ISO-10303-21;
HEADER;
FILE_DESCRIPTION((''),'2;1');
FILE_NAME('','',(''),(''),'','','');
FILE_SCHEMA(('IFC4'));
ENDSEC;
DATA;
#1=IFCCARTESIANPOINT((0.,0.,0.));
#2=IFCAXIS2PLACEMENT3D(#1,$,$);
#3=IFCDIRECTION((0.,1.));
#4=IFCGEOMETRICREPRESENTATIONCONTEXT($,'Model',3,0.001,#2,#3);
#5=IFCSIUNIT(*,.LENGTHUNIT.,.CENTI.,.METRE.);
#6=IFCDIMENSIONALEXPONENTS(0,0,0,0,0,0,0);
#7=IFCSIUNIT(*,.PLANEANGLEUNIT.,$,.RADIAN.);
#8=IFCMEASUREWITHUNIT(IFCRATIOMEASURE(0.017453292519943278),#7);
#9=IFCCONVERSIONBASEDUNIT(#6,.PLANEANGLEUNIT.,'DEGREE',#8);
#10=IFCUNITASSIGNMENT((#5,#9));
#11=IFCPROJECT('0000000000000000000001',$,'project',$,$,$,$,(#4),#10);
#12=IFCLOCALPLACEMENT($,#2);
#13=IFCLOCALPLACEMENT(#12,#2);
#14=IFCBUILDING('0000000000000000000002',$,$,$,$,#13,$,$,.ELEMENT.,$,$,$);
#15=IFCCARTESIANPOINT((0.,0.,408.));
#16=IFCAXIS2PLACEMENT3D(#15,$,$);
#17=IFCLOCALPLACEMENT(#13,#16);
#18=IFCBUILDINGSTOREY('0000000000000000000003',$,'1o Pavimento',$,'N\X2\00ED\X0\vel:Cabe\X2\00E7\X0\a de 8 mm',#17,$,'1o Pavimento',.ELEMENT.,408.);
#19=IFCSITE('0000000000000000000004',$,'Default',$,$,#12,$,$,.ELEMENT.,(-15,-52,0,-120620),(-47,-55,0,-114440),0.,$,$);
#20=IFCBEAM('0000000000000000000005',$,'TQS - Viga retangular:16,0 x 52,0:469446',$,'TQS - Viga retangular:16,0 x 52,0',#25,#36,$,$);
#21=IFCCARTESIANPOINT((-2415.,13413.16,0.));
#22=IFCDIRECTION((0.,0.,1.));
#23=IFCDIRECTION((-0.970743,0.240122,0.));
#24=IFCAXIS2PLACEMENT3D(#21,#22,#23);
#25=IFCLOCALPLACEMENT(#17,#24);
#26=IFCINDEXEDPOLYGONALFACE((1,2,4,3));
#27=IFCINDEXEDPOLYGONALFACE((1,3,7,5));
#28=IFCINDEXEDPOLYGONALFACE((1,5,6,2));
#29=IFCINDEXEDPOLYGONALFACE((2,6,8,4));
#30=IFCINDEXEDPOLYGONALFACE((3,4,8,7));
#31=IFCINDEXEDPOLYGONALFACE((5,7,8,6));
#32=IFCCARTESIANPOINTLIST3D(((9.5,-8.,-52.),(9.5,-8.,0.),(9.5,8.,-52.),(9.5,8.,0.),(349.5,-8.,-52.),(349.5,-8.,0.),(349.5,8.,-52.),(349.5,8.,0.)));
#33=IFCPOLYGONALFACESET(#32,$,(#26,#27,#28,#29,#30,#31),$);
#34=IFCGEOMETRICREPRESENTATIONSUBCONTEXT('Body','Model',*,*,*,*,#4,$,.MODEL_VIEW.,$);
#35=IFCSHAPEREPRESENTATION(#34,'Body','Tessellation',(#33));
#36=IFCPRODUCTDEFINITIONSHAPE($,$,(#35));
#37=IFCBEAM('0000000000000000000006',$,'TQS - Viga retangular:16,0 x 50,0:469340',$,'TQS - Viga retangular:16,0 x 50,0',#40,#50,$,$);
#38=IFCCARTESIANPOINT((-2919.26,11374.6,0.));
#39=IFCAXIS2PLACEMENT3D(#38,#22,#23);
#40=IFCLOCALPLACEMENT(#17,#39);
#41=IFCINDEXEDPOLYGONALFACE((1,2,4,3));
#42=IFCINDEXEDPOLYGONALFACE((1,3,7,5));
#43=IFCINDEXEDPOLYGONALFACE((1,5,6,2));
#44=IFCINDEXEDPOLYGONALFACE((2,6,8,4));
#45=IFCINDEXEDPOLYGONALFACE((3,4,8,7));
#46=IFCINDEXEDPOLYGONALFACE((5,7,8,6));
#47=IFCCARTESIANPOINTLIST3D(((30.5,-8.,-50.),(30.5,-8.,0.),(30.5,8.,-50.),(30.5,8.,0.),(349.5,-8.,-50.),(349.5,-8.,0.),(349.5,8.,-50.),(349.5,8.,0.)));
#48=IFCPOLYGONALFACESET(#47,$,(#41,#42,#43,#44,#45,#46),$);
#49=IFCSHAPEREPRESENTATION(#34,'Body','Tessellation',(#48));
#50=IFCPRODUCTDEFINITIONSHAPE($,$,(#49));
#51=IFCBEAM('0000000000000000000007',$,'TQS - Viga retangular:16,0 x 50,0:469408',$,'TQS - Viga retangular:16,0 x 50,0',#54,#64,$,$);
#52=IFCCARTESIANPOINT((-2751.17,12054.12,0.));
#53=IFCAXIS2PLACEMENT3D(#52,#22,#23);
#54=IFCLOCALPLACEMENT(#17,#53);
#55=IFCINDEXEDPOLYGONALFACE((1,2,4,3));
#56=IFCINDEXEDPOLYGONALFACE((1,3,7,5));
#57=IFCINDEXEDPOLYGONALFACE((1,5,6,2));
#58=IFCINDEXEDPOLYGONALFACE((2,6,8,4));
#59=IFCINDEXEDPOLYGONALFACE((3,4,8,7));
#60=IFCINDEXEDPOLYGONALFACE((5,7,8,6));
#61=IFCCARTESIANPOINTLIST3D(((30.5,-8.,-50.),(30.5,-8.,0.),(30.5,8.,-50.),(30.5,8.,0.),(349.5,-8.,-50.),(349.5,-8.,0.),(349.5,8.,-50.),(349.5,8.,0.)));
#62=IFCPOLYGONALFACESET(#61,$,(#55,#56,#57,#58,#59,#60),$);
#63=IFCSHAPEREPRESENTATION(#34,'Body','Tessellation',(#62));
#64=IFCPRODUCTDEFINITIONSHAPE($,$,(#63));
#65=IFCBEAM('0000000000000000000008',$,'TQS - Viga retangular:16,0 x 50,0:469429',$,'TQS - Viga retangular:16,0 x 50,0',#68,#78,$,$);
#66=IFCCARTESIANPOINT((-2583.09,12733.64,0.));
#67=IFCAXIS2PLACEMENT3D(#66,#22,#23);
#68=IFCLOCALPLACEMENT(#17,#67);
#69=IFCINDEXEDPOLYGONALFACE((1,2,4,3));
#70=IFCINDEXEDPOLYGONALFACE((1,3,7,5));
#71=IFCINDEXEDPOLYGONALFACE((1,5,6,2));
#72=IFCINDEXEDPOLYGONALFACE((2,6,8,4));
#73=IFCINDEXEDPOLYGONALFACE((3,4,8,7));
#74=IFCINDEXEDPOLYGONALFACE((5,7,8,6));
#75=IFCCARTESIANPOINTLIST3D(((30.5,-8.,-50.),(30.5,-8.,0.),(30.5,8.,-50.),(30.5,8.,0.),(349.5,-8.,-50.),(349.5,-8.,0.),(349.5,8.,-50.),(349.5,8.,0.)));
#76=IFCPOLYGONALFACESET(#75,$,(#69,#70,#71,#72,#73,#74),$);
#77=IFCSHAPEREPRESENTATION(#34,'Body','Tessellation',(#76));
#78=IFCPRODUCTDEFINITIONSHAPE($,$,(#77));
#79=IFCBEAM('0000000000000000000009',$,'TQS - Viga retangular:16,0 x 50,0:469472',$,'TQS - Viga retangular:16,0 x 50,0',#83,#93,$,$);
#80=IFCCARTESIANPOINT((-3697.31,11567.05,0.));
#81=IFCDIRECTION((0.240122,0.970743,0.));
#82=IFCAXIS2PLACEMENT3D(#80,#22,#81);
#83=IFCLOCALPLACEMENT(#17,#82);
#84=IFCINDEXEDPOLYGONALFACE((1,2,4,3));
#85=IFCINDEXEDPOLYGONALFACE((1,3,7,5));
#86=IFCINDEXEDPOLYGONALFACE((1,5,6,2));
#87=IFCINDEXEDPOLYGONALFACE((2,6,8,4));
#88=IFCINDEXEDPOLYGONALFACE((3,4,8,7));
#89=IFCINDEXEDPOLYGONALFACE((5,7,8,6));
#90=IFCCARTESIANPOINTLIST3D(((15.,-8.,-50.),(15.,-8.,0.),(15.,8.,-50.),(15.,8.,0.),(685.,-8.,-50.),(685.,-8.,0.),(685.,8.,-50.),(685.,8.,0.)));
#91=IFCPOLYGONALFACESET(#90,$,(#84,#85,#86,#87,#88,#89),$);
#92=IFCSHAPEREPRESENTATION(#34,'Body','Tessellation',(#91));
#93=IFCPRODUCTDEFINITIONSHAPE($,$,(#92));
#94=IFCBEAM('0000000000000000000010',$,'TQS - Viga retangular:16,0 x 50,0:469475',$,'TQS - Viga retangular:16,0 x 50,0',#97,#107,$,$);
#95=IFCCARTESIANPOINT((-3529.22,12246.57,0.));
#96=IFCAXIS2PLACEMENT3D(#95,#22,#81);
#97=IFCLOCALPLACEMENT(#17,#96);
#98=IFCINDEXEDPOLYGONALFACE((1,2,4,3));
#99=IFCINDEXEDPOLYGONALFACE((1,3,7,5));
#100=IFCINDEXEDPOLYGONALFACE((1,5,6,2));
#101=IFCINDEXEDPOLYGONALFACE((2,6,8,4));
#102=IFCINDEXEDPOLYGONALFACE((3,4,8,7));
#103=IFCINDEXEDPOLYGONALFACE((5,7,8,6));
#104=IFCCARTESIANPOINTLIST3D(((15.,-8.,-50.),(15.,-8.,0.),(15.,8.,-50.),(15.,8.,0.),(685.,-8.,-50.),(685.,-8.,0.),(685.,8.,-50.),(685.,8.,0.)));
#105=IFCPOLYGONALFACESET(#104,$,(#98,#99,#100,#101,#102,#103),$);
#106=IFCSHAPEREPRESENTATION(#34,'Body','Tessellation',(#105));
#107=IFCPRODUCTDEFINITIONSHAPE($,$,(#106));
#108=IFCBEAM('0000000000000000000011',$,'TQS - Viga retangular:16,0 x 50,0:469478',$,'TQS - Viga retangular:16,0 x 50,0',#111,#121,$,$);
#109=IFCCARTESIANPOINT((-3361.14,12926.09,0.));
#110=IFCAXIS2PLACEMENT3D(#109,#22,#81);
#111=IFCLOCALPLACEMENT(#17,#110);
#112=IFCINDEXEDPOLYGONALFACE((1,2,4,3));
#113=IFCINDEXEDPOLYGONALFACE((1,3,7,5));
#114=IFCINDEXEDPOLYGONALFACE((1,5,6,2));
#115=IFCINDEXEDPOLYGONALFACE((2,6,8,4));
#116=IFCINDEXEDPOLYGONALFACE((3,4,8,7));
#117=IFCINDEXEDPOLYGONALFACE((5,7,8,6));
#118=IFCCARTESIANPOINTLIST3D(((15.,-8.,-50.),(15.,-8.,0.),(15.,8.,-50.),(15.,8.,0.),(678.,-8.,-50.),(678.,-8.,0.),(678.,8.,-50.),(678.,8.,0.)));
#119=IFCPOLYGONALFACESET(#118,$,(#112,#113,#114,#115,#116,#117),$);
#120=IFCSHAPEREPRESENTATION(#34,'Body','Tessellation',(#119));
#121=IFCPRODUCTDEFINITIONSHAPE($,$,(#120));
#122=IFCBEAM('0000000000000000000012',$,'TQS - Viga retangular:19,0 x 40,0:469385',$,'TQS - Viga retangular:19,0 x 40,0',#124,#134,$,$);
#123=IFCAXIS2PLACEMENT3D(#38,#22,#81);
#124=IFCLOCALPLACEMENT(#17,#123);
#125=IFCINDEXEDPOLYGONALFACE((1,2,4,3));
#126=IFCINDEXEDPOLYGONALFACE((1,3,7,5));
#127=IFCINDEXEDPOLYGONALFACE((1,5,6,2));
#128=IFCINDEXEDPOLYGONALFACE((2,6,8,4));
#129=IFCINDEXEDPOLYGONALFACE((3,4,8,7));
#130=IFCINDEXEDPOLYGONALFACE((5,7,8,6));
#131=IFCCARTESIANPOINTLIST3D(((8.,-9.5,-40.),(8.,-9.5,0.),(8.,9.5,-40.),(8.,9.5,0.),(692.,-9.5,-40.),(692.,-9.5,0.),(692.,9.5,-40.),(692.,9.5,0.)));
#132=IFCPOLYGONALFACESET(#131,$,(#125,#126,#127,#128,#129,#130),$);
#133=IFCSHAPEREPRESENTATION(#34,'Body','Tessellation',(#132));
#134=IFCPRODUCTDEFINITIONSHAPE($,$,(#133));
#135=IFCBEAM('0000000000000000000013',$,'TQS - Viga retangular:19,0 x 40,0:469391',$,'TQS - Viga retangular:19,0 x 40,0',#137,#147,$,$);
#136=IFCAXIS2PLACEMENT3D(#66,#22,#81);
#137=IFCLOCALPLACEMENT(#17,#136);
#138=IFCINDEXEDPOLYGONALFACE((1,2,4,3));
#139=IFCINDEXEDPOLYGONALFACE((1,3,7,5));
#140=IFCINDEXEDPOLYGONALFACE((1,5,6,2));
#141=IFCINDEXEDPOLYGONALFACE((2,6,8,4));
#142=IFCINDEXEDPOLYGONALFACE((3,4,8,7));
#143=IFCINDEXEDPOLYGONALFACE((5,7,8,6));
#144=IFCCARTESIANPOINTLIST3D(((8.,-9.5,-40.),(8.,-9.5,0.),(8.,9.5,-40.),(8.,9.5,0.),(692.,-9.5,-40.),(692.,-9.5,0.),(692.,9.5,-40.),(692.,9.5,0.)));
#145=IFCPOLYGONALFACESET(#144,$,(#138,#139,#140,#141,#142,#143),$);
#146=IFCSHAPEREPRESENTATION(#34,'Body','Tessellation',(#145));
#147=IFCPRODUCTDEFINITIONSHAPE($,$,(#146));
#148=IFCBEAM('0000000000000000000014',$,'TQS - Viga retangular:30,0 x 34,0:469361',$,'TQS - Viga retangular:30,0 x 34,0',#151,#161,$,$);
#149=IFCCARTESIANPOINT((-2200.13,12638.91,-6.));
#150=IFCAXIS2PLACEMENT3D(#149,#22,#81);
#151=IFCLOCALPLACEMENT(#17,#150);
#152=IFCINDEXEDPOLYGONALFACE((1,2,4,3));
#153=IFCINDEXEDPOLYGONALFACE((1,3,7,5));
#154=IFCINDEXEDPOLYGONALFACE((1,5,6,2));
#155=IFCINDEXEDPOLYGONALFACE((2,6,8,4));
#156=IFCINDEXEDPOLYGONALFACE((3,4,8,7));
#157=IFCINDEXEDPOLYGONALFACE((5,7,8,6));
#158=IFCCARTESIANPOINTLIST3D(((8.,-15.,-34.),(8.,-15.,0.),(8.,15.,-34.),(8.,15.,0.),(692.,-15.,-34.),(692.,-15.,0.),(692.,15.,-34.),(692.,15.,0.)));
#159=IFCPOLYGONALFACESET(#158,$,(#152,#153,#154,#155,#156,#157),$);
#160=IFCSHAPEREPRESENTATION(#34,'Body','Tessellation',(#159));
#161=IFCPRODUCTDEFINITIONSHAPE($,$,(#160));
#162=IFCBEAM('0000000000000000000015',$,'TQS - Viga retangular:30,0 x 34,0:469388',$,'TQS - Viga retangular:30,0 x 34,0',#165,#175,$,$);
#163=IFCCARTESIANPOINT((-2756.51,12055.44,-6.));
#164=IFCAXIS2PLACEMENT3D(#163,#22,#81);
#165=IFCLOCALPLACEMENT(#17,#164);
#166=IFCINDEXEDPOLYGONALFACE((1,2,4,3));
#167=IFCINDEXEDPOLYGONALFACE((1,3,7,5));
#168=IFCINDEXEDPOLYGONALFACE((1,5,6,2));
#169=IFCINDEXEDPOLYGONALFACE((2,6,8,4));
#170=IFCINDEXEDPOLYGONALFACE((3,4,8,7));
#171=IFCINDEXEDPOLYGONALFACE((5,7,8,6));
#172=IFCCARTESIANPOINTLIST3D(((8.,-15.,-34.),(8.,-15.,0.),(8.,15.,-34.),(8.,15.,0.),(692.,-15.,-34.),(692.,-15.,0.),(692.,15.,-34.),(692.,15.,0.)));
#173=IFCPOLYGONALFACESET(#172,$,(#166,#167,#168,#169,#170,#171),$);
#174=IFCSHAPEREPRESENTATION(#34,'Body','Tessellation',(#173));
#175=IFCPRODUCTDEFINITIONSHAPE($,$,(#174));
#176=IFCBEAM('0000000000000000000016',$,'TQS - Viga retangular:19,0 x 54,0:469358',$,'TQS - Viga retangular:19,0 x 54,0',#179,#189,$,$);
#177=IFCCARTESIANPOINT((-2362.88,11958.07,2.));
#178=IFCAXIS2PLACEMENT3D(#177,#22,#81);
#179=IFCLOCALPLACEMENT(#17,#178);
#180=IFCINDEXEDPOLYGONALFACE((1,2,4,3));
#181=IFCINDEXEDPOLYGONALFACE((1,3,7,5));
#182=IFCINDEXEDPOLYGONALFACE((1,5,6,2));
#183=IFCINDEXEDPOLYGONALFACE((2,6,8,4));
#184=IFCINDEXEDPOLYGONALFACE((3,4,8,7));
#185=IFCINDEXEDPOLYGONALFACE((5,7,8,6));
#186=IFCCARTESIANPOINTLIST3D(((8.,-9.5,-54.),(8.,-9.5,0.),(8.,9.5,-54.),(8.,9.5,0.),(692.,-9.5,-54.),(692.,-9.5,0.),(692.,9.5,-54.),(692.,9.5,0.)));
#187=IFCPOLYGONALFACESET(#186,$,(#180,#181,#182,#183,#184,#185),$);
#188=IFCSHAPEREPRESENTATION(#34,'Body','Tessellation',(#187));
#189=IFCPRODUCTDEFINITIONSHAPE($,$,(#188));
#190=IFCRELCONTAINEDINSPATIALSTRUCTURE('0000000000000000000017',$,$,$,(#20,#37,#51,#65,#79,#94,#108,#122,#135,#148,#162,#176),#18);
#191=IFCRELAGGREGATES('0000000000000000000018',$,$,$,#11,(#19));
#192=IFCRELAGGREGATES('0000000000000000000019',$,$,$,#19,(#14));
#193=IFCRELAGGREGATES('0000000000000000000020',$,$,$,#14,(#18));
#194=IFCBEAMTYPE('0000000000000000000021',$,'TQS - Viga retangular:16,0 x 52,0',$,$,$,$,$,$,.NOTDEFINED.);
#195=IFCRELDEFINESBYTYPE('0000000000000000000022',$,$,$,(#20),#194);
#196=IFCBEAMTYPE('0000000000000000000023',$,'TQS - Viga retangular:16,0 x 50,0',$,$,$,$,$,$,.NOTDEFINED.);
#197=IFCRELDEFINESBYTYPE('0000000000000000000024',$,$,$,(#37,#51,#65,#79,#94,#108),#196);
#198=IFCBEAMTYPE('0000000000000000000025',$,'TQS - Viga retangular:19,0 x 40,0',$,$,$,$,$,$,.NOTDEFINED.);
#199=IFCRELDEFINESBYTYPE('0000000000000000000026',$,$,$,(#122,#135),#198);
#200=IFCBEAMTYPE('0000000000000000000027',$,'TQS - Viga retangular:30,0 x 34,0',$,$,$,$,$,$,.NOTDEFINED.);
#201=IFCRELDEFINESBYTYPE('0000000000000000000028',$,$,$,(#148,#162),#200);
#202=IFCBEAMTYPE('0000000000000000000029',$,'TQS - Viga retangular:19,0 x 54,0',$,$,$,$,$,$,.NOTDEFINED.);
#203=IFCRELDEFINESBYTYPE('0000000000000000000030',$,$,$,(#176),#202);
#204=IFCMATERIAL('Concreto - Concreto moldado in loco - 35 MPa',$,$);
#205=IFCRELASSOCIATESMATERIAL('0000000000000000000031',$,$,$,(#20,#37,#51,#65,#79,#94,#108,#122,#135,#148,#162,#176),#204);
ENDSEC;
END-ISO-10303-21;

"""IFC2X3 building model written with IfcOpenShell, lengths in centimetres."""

from ifc_helpers import new_model, entity, si_unit, converted_unit, direction, frame, frame_2d, origin, origin_2d_with_axis, place, context, subcontext, project, spatial, rectangle, extrude, material, type_object, element, save


model = new_model("IFC2X3")

# Units and contexts
model_context = context("Model", 3, precision=0.001, world=origin(), true_north=direction((0.0, 1.0)))
body_context = subcontext(model_context, "Body", "Model", "MODEL_VIEW")
ifc_project = project(units=[si_unit("LENGTHUNIT", "METRE", prefix="CENTI"), converted_unit("PLANEANGLEUNIT", "DEGREE", entity("IfcRatioMeasure", 0.017453292519943278), si_unit("PLANEANGLEUNIT", "RADIAN"), dimensions=[0, 0, 0, 0, 0, 0, 0])], contexts=[model_context])

# Site, building, storey
site_placement = place(None, origin())
site = spatial("IfcSite", under=ifc_project, at=site_placement, Name="Default", CompositionType="ELEMENT", RefLatitude=(-15, -52, 0, -120620), RefLongitude=(-47, -55, 0, -114440), RefElevation=0.0)
building_placement = place(site_placement, origin())
building = spatial("IfcBuilding", under=site, at=building_placement, CompositionType="ELEMENT")
storey_placement = place(building_placement, frame((0.0, 0.0, 408.0)))
storey = spatial("IfcBuildingStorey", under=building, at=storey_placement, Name="1o Pavimento", ObjectType="Nível:Cabeça de 8 mm", LongName="1o Pavimento", CompositionType="ELEMENT", Elevation=408.0)

# Beams
ifc_material_1 = material(Name="Concreto - Concreto moldado in loco - 35 MPa")
beam_type_1 = type_object("IfcBeamType", Name="TQS - Viga retangular:16,0 x 52,0", PredefinedType="NOTDEFINED")
beam_1_placement = place(storey_placement, frame((-2415.0, 13413.16, 0.0), z_axis=(0.0, 0.0, 1.0), x_axis=(-0.970743, 0.240122, 0.0)))
element("IfcBeam", 1, at=beam_1_placement, inside=storey, type_object=beam_type_1, material=ifc_material_1, Name="TQS - Viga retangular:16,0 x 52,0:469446", ObjectType="TQS - Viga retangular:16,0 x 52,0", context=body_context, shape_type="SweptSolid", body=[
    extrude(rectangle(XDim=52.0, YDim=16.0, at=frame_2d((0.0, 0.0), x_axis=(1.0, 0.0))), frame((9.5, 0.0, -26.0), z_axis=(1.0, 0.0, 0.0), x_axis=(0.0, 0.0, -1.0)), (0.0, 0.0, 1.0), 340.0),
])
beam_type_2 = type_object("IfcBeamType", Name="TQS - Viga retangular:16,0 x 50,0", PredefinedType="NOTDEFINED")
beam_2_placement = place(storey_placement, frame((-2919.26, 11374.6, 0.0), z_axis=(0.0, 0.0, 1.0), x_axis=(-0.970743, 0.240122, 0.0)))
element("IfcBeam", 2, at=beam_2_placement, inside=storey, type_object=beam_type_2, material=ifc_material_1, Name="TQS - Viga retangular:16,0 x 50,0:469340", ObjectType="TQS - Viga retangular:16,0 x 50,0", context=body_context, shape_type="SweptSolid", body=[
    extrude(rectangle(XDim=50.0, YDim=16.0, at=frame_2d((0.0, 0.0), x_axis=(1.0, 0.0))), frame((30.5, 0.0, -25.0), z_axis=(1.0, 0.0, 0.0), x_axis=(0.0, 0.0, -1.0)), (0.0, 0.0, 1.0), 319.0),
])
beam_3_placement = place(storey_placement, frame((-2751.17, 12054.12, 0.0), z_axis=(0.0, 0.0, 1.0), x_axis=(-0.970743, 0.240122, 0.0)))
element("IfcBeam", 3, at=beam_3_placement, inside=storey, type_object=beam_type_2, material=ifc_material_1, Name="TQS - Viga retangular:16,0 x 50,0:469408", ObjectType="TQS - Viga retangular:16,0 x 50,0", context=body_context, shape_type="SweptSolid", body=[
    extrude(rectangle(XDim=50.0, YDim=16.0, at=frame_2d((0.0, 0.0), x_axis=(1.0, 0.0))), frame((30.5, 0.0, -25.0), z_axis=(1.0, 0.0, 0.0), x_axis=(0.0, 0.0, -1.0)), (0.0, 0.0, 1.0), 319.0),
])
beam_4_placement = place(storey_placement, frame((-2583.09, 12733.64, 0.0), z_axis=(0.0, 0.0, 1.0), x_axis=(-0.970743, 0.240122, 0.0)))
element("IfcBeam", 4, at=beam_4_placement, inside=storey, type_object=beam_type_2, material=ifc_material_1, Name="TQS - Viga retangular:16,0 x 50,0:469429", ObjectType="TQS - Viga retangular:16,0 x 50,0", context=body_context, shape_type="SweptSolid", body=[
    extrude(rectangle(XDim=50.0, YDim=16.0, at=frame_2d((0.0, 0.0), x_axis=(1.0, 0.0))), frame((30.5, 0.0, -25.0), z_axis=(1.0, 0.0, 0.0), x_axis=(0.0, 0.0, -1.0)), (0.0, 0.0, 1.0), 319.0),
])
beam_5_placement = place(storey_placement, frame((-3697.31, 11567.05, 0.0), z_axis=(0.0, 0.0, 1.0), x_axis=(0.240122, 0.970743, 0.0)))
element("IfcBeam", 5, at=beam_5_placement, inside=storey, type_object=beam_type_2, material=ifc_material_1, Name="TQS - Viga retangular:16,0 x 50,0:469472", ObjectType="TQS - Viga retangular:16,0 x 50,0", context=body_context, shape_type="SweptSolid", body=[
    extrude(rectangle(XDim=50.0, YDim=16.0, at=frame_2d((0.0, 0.0), x_axis=(1.0, 0.0))), frame((15.0, 0.0, -25.0), z_axis=(1.0, 0.0, 0.0), x_axis=(0.0, 0.0, -1.0)), (0.0, 0.0, 1.0), 670.0),
])
beam_6_placement = place(storey_placement, frame((-3529.22, 12246.57, 0.0), z_axis=(0.0, 0.0, 1.0), x_axis=(0.240122, 0.970743, 0.0)))
element("IfcBeam", 6, at=beam_6_placement, inside=storey, type_object=beam_type_2, material=ifc_material_1, Name="TQS - Viga retangular:16,0 x 50,0:469475", ObjectType="TQS - Viga retangular:16,0 x 50,0", context=body_context, shape_type="SweptSolid", body=[
    extrude(rectangle(XDim=50.0, YDim=16.0, at=frame_2d((0.0, 0.0), x_axis=(1.0, 0.0))), frame((15.0, 0.0, -25.0), z_axis=(1.0, 0.0, 0.0), x_axis=(0.0, 0.0, -1.0)), (0.0, 0.0, 1.0), 670.0),
])
beam_7_placement = place(storey_placement, frame((-3361.14, 12926.09, 0.0), z_axis=(0.0, 0.0, 1.0), x_axis=(0.240122, 0.970743, 0.0)))
element("IfcBeam", 7, at=beam_7_placement, inside=storey, type_object=beam_type_2, material=ifc_material_1, Name="TQS - Viga retangular:16,0 x 50,0:469478", ObjectType="TQS - Viga retangular:16,0 x 50,0", context=body_context, shape_type="SweptSolid", body=[
    extrude(rectangle(XDim=50.0, YDim=16.0, at=origin_2d_with_axis()), frame((15.0, 0.0, -25.0), z_axis=(1.0, 0.0, 0.0), x_axis=(0.0, 0.0, -1.0)), (0.0, 0.0, 1.0), 663.0),
])
beam_type_3 = type_object("IfcBeamType", Name="TQS - Viga retangular:19,0 x 40,0", PredefinedType="NOTDEFINED")
beam_8_placement = place(storey_placement, frame((-2919.26, 11374.6, 0.0), z_axis=(0.0, 0.0, 1.0), x_axis=(0.240122, 0.970743, 0.0)))
element("IfcBeam", 8, at=beam_8_placement, inside=storey, type_object=beam_type_3, material=ifc_material_1, Name="TQS - Viga retangular:19,0 x 40,0:469385", ObjectType="TQS - Viga retangular:19,0 x 40,0", context=body_context, shape_type="SweptSolid", body=[
    extrude(rectangle(XDim=40.0, YDim=19.0, at=origin_2d_with_axis()), frame((8.0, 0.0, -20.0), z_axis=(1.0, 0.0, 0.0), x_axis=(0.0, 0.0, -1.0)), (0.0, 0.0, 1.0), 684.0),
])
beam_9_placement = place(storey_placement, frame((-2583.09, 12733.64, 0.0), z_axis=(0.0, 0.0, 1.0), x_axis=(0.240122, 0.970743, 0.0)))
element("IfcBeam", 9, at=beam_9_placement, inside=storey, type_object=beam_type_3, material=ifc_material_1, Name="TQS - Viga retangular:19,0 x 40,0:469391", ObjectType="TQS - Viga retangular:19,0 x 40,0", context=body_context, shape_type="SweptSolid", body=[
    extrude(rectangle(XDim=40.0, YDim=19.0, at=frame_2d((0.0, 0.0), x_axis=(1.0, 0.0))), frame((8.0, 0.0, -20.0), z_axis=(1.0, 0.0, 0.0), x_axis=(0.0, 0.0, -1.0)), (0.0, 0.0, 1.0), 684.0),
])
beam_type_4 = type_object("IfcBeamType", Name="TQS - Viga retangular:30,0 x 34,0", PredefinedType="NOTDEFINED")
beam_10_placement = place(storey_placement, frame((-2200.13, 12638.91, -6.0), z_axis=(0.0, 0.0, 1.0), x_axis=(0.240122, 0.970743, 0.0)))
element("IfcBeam", 10, at=beam_10_placement, inside=storey, type_object=beam_type_4, material=ifc_material_1, Name="TQS - Viga retangular:30,0 x 34,0:469361", ObjectType="TQS - Viga retangular:30,0 x 34,0", context=body_context, shape_type="SweptSolid", body=[
    extrude(rectangle(XDim=34.0, YDim=30.0, at=frame_2d((0.0, 0.0), x_axis=(1.0, 0.0))), frame((8.0, 0.0, -17.0), z_axis=(1.0, 0.0, 0.0), x_axis=(0.0, 0.0, -1.0)), (0.0, 0.0, 1.0), 684.0),
])
beam_11_placement = place(storey_placement, frame((-2756.51, 12055.44, -6.0), z_axis=(0.0, 0.0, 1.0), x_axis=(0.240122, 0.970743, 0.0)))
element("IfcBeam", 11, at=beam_11_placement, inside=storey, type_object=beam_type_4, material=ifc_material_1, Name="TQS - Viga retangular:30,0 x 34,0:469388", ObjectType="TQS - Viga retangular:30,0 x 34,0", context=body_context, shape_type="SweptSolid", body=[
    extrude(rectangle(XDim=34.0, YDim=30.0, at=frame_2d((0.0, 0.0), x_axis=(1.0, 0.0))), frame((8.0, 0.0, -17.0), z_axis=(1.0, 0.0, 0.0), x_axis=(0.0, 0.0, -1.0)), (0.0, 0.0, 1.0), 684.0),
])
beam_type_5 = type_object("IfcBeamType", Name="TQS - Viga retangular:19,0 x 54,0", PredefinedType="NOTDEFINED")
beam_12_placement = place(storey_placement, frame((-2362.88, 11958.07, 2.0), z_axis=(0.0, 0.0, 1.0), x_axis=(0.240122, 0.970743, 0.0)))
element("IfcBeam", 12, at=beam_12_placement, inside=storey, type_object=beam_type_5, material=ifc_material_1, Name="TQS - Viga retangular:19,0 x 54,0:469358", ObjectType="TQS - Viga retangular:19,0 x 54,0", context=body_context, shape_type="SweptSolid", body=[
    extrude(rectangle(XDim=54.0, YDim=19.0, at=origin_2d_with_axis()), frame((8.0, 0.0, -27.0), z_axis=(1.0, 0.0, 0.0), x_axis=(0.0, 0.0, -1.0)), (0.0, 0.0, 1.0), 684.0),
])

save(model, "model.ifc")
